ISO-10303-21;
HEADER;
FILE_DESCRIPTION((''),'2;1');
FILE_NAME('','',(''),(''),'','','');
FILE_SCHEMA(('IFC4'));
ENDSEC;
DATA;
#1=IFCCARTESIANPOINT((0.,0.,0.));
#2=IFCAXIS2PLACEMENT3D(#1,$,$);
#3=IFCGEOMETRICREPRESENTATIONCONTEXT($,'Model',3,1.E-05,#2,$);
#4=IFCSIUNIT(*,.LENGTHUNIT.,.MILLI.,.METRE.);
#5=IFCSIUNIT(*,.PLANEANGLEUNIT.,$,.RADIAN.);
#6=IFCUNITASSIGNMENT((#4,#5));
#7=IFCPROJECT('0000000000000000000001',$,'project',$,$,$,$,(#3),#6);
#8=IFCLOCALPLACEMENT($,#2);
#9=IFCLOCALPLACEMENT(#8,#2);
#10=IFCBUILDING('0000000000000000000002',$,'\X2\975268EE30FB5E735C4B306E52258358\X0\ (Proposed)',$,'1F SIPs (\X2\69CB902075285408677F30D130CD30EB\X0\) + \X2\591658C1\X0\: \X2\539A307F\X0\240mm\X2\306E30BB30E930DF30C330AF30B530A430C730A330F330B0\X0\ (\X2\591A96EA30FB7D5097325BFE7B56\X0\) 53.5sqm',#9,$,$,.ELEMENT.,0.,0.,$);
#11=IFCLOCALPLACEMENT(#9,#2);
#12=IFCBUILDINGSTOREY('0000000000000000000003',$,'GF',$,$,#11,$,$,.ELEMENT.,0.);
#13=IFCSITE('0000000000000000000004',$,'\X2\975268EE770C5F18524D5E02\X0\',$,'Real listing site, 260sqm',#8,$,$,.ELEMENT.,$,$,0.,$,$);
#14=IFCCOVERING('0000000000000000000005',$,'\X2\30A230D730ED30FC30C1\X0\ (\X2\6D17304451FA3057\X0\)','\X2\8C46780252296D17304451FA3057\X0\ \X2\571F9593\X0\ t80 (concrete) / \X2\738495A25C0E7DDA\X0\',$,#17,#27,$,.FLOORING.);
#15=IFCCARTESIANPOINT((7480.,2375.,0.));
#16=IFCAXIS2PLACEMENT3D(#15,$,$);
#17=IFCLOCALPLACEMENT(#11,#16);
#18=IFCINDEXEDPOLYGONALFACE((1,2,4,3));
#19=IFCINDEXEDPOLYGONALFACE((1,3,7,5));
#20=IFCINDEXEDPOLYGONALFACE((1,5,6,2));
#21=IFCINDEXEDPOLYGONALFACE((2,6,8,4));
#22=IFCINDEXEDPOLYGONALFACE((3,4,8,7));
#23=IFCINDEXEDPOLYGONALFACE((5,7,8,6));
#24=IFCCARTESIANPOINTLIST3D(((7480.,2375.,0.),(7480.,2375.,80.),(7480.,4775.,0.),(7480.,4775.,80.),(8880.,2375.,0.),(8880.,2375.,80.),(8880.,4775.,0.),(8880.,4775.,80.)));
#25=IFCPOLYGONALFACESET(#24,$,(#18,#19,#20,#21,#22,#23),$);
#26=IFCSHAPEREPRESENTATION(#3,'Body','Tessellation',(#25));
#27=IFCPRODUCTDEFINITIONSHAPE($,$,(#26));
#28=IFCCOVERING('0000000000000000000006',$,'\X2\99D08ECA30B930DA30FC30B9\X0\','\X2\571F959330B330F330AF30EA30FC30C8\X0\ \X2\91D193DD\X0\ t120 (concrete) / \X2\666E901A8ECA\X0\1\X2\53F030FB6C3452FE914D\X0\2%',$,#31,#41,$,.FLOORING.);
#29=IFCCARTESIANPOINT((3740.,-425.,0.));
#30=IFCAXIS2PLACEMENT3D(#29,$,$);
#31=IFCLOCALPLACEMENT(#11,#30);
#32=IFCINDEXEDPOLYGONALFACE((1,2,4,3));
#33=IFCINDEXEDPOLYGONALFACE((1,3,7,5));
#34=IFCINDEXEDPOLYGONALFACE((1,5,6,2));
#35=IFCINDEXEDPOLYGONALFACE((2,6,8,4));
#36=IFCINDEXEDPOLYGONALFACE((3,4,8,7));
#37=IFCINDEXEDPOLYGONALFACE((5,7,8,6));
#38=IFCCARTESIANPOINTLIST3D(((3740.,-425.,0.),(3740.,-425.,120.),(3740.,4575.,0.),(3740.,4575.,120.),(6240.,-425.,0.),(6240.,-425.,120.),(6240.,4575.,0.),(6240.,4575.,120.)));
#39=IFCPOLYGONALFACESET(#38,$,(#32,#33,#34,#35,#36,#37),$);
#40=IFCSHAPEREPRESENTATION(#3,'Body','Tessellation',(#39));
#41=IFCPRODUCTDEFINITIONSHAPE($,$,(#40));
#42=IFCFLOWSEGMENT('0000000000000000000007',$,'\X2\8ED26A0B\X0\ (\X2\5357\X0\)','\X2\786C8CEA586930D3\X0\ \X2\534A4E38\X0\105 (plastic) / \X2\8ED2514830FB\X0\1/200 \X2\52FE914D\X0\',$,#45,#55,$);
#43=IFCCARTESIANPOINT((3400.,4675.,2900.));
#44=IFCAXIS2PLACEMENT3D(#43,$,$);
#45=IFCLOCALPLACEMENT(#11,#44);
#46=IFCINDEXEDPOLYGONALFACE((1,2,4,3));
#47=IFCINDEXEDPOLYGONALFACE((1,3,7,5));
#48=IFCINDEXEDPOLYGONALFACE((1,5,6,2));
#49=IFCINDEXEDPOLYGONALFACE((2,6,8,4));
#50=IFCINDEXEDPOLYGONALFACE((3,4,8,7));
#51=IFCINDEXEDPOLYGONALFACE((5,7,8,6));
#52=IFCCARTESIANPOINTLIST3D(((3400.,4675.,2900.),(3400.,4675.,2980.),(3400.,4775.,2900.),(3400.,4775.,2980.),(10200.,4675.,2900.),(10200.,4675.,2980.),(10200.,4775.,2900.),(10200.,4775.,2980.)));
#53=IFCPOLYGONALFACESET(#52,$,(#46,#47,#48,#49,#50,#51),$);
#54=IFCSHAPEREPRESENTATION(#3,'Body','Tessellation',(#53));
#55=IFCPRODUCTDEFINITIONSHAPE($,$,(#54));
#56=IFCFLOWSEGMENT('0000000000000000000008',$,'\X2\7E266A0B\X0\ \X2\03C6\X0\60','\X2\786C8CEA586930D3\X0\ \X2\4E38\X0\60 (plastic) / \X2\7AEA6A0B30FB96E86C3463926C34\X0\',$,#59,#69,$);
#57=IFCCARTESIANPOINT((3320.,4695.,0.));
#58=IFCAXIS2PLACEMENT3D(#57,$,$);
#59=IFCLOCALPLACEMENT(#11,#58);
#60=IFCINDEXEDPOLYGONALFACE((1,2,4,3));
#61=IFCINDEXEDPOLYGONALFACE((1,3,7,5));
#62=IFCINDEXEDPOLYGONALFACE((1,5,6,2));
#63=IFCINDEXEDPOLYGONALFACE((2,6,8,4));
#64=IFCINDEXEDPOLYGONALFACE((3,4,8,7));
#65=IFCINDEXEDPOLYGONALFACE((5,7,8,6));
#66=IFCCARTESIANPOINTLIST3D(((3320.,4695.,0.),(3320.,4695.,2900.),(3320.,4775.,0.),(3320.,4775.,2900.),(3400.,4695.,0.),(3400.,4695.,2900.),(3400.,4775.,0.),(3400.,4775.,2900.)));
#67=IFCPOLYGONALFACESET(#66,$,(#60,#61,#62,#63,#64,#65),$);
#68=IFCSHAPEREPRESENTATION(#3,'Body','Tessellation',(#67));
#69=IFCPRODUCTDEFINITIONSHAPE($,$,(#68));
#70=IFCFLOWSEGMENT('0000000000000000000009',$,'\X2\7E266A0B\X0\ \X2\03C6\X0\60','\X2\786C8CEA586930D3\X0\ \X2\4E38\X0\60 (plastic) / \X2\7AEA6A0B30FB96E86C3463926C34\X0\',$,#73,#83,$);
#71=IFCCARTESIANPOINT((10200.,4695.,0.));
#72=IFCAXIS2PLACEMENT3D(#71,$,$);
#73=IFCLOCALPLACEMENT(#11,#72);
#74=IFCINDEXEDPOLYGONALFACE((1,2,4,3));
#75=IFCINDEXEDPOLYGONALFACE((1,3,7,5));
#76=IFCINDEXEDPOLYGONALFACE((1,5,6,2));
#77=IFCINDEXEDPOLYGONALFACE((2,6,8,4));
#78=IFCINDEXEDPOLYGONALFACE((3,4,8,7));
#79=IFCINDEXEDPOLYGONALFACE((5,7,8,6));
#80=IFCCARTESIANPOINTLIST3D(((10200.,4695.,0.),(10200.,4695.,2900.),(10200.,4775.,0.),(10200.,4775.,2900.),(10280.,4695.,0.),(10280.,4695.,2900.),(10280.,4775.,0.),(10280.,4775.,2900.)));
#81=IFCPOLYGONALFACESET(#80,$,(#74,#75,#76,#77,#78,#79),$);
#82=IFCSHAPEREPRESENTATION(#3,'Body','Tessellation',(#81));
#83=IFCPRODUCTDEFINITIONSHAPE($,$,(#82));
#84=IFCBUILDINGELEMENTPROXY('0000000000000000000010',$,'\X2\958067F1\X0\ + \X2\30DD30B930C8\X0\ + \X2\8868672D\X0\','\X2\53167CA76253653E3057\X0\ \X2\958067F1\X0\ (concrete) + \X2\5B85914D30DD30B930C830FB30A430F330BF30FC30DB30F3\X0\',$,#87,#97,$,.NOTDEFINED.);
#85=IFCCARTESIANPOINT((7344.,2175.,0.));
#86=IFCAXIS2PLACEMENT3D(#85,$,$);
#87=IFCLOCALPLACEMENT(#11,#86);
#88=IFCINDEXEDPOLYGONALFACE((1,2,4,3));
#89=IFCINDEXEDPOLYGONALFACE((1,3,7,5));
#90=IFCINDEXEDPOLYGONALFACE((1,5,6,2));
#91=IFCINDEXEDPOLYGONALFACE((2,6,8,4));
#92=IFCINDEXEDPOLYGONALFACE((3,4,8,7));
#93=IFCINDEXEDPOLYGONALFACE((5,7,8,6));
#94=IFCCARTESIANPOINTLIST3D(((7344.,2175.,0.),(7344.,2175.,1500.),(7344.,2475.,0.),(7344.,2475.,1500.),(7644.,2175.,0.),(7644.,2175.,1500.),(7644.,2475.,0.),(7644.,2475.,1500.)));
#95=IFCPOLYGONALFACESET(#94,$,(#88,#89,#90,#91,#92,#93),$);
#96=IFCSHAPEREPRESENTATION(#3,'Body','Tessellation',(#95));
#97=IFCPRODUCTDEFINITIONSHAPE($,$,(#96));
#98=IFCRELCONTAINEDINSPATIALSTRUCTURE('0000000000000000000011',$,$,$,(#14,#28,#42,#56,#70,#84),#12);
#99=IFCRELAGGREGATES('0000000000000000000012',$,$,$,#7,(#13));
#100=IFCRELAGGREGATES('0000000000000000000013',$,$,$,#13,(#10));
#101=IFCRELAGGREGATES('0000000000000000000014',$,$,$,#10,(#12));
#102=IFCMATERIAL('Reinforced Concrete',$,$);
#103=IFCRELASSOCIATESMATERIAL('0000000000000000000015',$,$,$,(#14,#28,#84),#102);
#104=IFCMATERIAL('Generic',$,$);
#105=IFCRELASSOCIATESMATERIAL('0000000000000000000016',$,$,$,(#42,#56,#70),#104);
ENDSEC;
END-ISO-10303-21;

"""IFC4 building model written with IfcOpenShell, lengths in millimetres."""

from ifc_helpers import new_model, si_unit, frame, frame_2d, origin, place, context, project, spatial, rectangle, extrude, material, element, save


model = new_model("IFC4")

# Units and contexts
model_context = context("Model", 3, precision=1e-05, world=origin())
ifc_project = project(units=[si_unit("LENGTHUNIT", "METRE", prefix="MILLI"), si_unit("PLANEANGLEUNIT", "RADIAN")], contexts=[model_context])

# Site, building, storey
site_placement = place(None, origin())
site = spatial("IfcSite", under=ifc_project, at=site_placement, Name="青森県弘前市", ObjectType="Real listing site, 260sqm", CompositionType="ELEMENT", RefElevation=0.0)
building_placement = place(site_placement, origin())
building = spatial("IfcBuilding", under=site, at=building_placement, Name="青森・平屋の別荘 (Proposed)", ObjectType="1F SIPs (構造用合板パネル) + 外壁: 厚み240mmのセラミックサイディング (多雪・結露対策) 53.5sqm", CompositionType="ELEMENT", ElevationOfRefHeight=0.0, ElevationOfTerrain=0.0)
storey_placement = place(building_placement, origin())
storey = spatial("IfcBuildingStorey", under=building, at=storey_placement, Name="GF", CompositionType="ELEMENT", Elevation=0.0)

# Shared definitions
ifc_material_1 = material(Name="Reinforced Concrete")

# Coverings
ifc_material_2 = material(Name="Generic")
covering_1_placement = place(storey_placement, frame((7480.0, 2375.0, 0.0)))
element("IfcCovering", 1, at=covering_1_placement, inside=storey, material=ifc_material_1, Name="アプローチ (洗い出し)", Description="豆砂利洗い出し 土間 t80 (concrete) / 玄関導線", PredefinedType="FLOORING", context=model_context, shape_type="SweptSolid", body=[
    extrude(rectangle(XDim=1400.0, YDim=2400.0, at=frame_2d((700.0, 1200.0))), frame((7480.0, 2375.0, 0.0)), (0.0, 0.0, 1.0), 80.0),
])
covering_2_placement = place(storey_placement, frame((3740.0, -425.0, 0.0)))
element("IfcCovering", 2, at=covering_2_placement, inside=storey, material=ifc_material_1, Name="駐車スペース", Description="土間コンクリート 金鏝 t120 (concrete) / 普通車1台・水勾配2%", PredefinedType="FLOORING", context=model_context, shape_type="SweptSolid", body=[
    extrude(rectangle(XDim=2500.0, YDim=5000.0, at=frame_2d((1250.0, 2500.0))), frame((3740.0, -425.0, 0.0)), (0.0, 0.0, 1.0), 120.0),
])

# Flow segments
flow_segment_1_placement = place(storey_placement, frame((3400.0, 4675.0, 2900.0)))
element("IfcFlowSegment", 3, at=flow_segment_1_placement, inside=storey, material=ifc_material_2, Name="軒樋 (南)", Description="硬質塩ビ 半丸105 (plastic) / 軒先・1/200 勾配", context=model_context, shape_type="SweptSolid", body=[
    extrude(rectangle(XDim=6800.0, YDim=100.0, at=frame_2d((3400.0, 50.0))), frame((3400.0, 4675.0, 2900.0)), (0.0, 0.0, 1.0), 80.0),
])
flow_segment_2_placement = place(storey_placement, frame((3320.0, 4695.0, 0.0)))
element("IfcFlowSegment", 4, at=flow_segment_2_placement, inside=storey, material=ifc_material_2, Name="縦樋 φ60", Description="硬質塩ビ 丸60 (plastic) / 竪樋・雨水排水", context=model_context, shape_type="SweptSolid", body=[
    extrude(rectangle(XDim=80.0, YDim=80.0, at=frame_2d((40.0, 40.0))), frame((3320.0, 4695.0, 0.0)), (0.0, 0.0, 1.0), 2900.0),
])
flow_segment_3_placement = place(storey_placement, frame((10200.0, 4695.0, 0.0)))
element("IfcFlowSegment", 5, at=flow_segment_3_placement, inside=storey, material=ifc_material_2, Name="縦樋 φ60", Description="硬質塩ビ 丸60 (plastic) / 竪樋・雨水排水", context=model_context, shape_type="SweptSolid", body=[
    extrude(rectangle(XDim=80.0, YDim=80.0, at=frame_2d((40.0, 40.0))), frame((10200.0, 4695.0, 0.0)), (0.0, 0.0, 1.0), 2900.0),
])

# Building element proxy
proxy_placement = place(storey_placement, frame((7344.0, 2175.0, 0.0)))
element("IfcBuildingElementProxy", 6, at=proxy_placement, inside=storey, material=ifc_material_1, Name="門柱 + ポスト + 表札", Description="化粧打放し 門柱 (concrete) + 宅配ポスト・インターホン", PredefinedType="NOTDEFINED", context=model_context, shape_type="SweptSolid", body=[
    extrude(rectangle(XDim=300.0, YDim=300.0, at=frame_2d((150.0, 150.0))), frame((7344.0, 2175.0, 0.0)), (0.0, 0.0, 1.0), 1500.0),
])

save(model, "model.ifc")
